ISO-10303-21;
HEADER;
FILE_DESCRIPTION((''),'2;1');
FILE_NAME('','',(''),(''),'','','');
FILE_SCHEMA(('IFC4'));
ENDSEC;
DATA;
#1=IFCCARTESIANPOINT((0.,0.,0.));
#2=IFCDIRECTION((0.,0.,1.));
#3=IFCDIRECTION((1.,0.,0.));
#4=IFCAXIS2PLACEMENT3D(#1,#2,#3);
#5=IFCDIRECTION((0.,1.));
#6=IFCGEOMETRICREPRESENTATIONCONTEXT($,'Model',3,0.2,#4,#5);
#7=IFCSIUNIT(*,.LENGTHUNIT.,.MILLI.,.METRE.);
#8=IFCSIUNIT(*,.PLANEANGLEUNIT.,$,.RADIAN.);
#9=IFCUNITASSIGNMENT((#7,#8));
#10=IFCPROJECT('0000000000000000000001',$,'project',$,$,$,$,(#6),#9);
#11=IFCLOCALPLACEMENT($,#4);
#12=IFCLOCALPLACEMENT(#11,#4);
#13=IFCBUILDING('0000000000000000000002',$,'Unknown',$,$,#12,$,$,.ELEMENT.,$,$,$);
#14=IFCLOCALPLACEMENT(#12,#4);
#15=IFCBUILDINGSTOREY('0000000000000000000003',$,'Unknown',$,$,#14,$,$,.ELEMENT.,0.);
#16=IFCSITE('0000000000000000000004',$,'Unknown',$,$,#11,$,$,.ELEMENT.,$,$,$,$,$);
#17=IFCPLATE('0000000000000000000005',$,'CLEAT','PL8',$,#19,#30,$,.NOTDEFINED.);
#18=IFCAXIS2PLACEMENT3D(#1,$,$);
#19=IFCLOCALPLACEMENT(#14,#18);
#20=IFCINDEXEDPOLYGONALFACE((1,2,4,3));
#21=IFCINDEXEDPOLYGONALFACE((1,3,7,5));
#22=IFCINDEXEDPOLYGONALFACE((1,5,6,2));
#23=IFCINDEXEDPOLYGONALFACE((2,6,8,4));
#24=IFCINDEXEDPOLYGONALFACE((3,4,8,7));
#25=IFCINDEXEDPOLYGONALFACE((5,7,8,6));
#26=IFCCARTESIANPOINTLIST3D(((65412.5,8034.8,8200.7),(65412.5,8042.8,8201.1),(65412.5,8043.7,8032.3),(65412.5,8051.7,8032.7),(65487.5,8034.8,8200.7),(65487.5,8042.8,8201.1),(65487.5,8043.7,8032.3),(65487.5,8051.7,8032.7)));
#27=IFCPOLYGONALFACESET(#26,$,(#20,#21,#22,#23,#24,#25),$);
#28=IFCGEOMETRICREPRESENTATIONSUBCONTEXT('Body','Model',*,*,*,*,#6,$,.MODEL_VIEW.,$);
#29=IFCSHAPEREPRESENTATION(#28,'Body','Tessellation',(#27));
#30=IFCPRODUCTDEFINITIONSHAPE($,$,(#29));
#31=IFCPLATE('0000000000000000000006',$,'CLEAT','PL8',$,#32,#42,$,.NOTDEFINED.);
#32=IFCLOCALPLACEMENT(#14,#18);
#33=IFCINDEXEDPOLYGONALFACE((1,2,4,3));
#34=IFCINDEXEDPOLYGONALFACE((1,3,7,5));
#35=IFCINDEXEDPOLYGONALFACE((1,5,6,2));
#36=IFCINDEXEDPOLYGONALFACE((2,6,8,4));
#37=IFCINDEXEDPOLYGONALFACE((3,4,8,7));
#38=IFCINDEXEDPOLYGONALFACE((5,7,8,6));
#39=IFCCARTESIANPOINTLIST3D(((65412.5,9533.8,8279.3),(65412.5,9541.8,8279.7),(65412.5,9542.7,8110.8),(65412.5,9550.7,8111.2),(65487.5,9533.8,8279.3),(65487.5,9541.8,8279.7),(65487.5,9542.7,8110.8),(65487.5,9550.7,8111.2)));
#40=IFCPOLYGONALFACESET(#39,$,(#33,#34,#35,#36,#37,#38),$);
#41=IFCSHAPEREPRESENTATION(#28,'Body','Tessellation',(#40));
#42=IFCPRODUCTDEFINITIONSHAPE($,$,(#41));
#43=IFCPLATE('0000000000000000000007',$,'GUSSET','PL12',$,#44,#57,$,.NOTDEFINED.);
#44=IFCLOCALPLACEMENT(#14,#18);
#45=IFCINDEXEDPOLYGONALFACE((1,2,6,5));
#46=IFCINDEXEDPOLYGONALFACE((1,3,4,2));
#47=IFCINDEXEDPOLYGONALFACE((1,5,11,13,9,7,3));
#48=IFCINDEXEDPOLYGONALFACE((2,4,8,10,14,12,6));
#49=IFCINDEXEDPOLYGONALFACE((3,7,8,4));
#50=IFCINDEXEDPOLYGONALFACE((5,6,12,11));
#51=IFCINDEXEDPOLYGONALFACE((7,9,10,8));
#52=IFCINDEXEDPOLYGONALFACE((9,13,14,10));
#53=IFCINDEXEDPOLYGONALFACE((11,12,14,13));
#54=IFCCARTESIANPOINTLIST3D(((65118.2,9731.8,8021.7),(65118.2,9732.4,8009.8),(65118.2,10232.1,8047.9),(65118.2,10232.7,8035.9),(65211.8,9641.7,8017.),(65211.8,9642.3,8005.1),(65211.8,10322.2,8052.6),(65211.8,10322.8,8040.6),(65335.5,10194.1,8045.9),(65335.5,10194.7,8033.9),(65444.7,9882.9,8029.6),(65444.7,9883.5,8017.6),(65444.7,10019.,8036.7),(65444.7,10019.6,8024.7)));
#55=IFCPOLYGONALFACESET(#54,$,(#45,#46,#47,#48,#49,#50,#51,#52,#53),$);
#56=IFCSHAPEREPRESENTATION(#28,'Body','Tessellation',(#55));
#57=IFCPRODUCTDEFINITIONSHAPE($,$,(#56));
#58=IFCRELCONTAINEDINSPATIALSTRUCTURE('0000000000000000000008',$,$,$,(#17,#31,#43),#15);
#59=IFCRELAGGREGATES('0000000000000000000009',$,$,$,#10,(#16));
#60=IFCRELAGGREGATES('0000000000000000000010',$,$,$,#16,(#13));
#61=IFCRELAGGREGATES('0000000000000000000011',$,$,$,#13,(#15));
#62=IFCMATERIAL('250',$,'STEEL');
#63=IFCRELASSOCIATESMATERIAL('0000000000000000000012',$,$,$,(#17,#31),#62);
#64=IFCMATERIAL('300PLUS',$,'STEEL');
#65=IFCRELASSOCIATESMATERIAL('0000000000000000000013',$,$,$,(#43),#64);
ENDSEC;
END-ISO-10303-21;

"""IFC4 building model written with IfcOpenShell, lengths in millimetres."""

from ifc_helpers import new_model, si_unit, direction, frame, origin_with_axes, place, context, subcontext, project, spatial, line, indexed_curve, outline, extrude, material, element, save


model = new_model("IFC4")

# Units and contexts
model_context = context("Model", 3, precision=0.2, world=origin_with_axes(), true_north=direction((0.0, 1.0)))
body_context = subcontext(model_context, "Body", "Model", "MODEL_VIEW")
ifc_project = project(units=[si_unit("LENGTHUNIT", "METRE", prefix="MILLI"), si_unit("PLANEANGLEUNIT", "RADIAN")], contexts=[model_context])

# Site, building, storey
site_placement = place(None, origin_with_axes())
site = spatial("IfcSite", under=ifc_project, at=site_placement, Name="Unknown", CompositionType="ELEMENT")
building_placement = place(site_placement, origin_with_axes())
building = spatial("IfcBuilding", under=site, at=building_placement, Name="Unknown", CompositionType="ELEMENT")
storey_placement = place(building_placement, origin_with_axes())
storey = spatial("IfcBuildingStorey", under=building, at=storey_placement, Name="Unknown", CompositionType="ELEMENT", Elevation=0.0)

# Shared definitions
ifc_material_1 = material(Name="300PLUS", Category="STEEL")

# Plates
ifc_material_2 = material(Name="250", Category="STEEL")
plate_1_placement = place(storey_placement, frame((65412.5, 8038.8, 8200.9), z_axis=(0.0, 0.998606, 0.052777), x_axis=(1.0, 0.0, 0.0)))
element("IfcPlate", 1, at=plate_1_placement, inside=storey, material=ifc_material_2, Name="CLEAT", Description="PL8", PredefinedType="NOTDEFINED", context=body_context, shape_type="SolidModel", body=[
    extrude(outline(indexed_curve([(0.0, 0.0), (75.0, 0.0), (75.0, 168.6), (0.0, 168.6)], segments=[line(1, 2, 3, 4, 1)])), frame((0.0, 0.0, 4.0), z_axis=(0.0, 0.0, 1.0), x_axis=(1.0, 0.0, 0.0)), (0.0, 0.0, -1.0), 8.0),
])
plate_2_placement = place(storey_placement, frame((65412.5, 9537.8, 8279.5), z_axis=(0.0, 0.998608, 0.052745), x_axis=(1.0, 0.0, 0.0)))
element("IfcPlate", 2, at=plate_2_placement, inside=storey, material=ifc_material_2, Name="CLEAT", Description="PL8", PredefinedType="NOTDEFINED", context=body_context, shape_type="SolidModel", body=[
    extrude(outline(indexed_curve([(0.0, 0.0), (75.0, 0.0), (75.0, 168.7), (0.0, 168.7)], segments=[line(1, 2, 3, 4, 1)])), frame((0.0, 0.0, 4.0), z_axis=(0.0, 0.0, 1.0), x_axis=(1.0, 0.0, 0.0)), (0.0, 0.0, -1.0), 8.0),
])
plate_3_placement = place(storey_placement, frame((65211.8, 10322.5, 8046.6), z_axis=(0.000069, -0.052165, 0.998638), x_axis=(-0.719977, -0.693055, -0.036153)))
element("IfcPlate", 3, at=plate_3_placement, inside=storey, material=ifc_material_1, Name="GUSSET", Description="PL12", PredefinedType="NOTDEFINED", context=body_context, shape_type="SolidModel", body=[
    extrude(outline(indexed_curve([(0.0, 0.0), (130.0, 0.0), (477.7, 360.7), (472.9, 490.6), (137.6, 478.4), (43.0, 380.2), (0.0, 178.2)], segments=[line(1, 2, 3, 4, 5, 6, 7, 1)])), frame((0.0, 0.0, 6.0), z_axis=(0.0, 0.0, 1.0), x_axis=(1.0, 0.0, 0.0)), (0.0, 0.0, -1.0), 12.0),
])

save(model, "model.ifc")
